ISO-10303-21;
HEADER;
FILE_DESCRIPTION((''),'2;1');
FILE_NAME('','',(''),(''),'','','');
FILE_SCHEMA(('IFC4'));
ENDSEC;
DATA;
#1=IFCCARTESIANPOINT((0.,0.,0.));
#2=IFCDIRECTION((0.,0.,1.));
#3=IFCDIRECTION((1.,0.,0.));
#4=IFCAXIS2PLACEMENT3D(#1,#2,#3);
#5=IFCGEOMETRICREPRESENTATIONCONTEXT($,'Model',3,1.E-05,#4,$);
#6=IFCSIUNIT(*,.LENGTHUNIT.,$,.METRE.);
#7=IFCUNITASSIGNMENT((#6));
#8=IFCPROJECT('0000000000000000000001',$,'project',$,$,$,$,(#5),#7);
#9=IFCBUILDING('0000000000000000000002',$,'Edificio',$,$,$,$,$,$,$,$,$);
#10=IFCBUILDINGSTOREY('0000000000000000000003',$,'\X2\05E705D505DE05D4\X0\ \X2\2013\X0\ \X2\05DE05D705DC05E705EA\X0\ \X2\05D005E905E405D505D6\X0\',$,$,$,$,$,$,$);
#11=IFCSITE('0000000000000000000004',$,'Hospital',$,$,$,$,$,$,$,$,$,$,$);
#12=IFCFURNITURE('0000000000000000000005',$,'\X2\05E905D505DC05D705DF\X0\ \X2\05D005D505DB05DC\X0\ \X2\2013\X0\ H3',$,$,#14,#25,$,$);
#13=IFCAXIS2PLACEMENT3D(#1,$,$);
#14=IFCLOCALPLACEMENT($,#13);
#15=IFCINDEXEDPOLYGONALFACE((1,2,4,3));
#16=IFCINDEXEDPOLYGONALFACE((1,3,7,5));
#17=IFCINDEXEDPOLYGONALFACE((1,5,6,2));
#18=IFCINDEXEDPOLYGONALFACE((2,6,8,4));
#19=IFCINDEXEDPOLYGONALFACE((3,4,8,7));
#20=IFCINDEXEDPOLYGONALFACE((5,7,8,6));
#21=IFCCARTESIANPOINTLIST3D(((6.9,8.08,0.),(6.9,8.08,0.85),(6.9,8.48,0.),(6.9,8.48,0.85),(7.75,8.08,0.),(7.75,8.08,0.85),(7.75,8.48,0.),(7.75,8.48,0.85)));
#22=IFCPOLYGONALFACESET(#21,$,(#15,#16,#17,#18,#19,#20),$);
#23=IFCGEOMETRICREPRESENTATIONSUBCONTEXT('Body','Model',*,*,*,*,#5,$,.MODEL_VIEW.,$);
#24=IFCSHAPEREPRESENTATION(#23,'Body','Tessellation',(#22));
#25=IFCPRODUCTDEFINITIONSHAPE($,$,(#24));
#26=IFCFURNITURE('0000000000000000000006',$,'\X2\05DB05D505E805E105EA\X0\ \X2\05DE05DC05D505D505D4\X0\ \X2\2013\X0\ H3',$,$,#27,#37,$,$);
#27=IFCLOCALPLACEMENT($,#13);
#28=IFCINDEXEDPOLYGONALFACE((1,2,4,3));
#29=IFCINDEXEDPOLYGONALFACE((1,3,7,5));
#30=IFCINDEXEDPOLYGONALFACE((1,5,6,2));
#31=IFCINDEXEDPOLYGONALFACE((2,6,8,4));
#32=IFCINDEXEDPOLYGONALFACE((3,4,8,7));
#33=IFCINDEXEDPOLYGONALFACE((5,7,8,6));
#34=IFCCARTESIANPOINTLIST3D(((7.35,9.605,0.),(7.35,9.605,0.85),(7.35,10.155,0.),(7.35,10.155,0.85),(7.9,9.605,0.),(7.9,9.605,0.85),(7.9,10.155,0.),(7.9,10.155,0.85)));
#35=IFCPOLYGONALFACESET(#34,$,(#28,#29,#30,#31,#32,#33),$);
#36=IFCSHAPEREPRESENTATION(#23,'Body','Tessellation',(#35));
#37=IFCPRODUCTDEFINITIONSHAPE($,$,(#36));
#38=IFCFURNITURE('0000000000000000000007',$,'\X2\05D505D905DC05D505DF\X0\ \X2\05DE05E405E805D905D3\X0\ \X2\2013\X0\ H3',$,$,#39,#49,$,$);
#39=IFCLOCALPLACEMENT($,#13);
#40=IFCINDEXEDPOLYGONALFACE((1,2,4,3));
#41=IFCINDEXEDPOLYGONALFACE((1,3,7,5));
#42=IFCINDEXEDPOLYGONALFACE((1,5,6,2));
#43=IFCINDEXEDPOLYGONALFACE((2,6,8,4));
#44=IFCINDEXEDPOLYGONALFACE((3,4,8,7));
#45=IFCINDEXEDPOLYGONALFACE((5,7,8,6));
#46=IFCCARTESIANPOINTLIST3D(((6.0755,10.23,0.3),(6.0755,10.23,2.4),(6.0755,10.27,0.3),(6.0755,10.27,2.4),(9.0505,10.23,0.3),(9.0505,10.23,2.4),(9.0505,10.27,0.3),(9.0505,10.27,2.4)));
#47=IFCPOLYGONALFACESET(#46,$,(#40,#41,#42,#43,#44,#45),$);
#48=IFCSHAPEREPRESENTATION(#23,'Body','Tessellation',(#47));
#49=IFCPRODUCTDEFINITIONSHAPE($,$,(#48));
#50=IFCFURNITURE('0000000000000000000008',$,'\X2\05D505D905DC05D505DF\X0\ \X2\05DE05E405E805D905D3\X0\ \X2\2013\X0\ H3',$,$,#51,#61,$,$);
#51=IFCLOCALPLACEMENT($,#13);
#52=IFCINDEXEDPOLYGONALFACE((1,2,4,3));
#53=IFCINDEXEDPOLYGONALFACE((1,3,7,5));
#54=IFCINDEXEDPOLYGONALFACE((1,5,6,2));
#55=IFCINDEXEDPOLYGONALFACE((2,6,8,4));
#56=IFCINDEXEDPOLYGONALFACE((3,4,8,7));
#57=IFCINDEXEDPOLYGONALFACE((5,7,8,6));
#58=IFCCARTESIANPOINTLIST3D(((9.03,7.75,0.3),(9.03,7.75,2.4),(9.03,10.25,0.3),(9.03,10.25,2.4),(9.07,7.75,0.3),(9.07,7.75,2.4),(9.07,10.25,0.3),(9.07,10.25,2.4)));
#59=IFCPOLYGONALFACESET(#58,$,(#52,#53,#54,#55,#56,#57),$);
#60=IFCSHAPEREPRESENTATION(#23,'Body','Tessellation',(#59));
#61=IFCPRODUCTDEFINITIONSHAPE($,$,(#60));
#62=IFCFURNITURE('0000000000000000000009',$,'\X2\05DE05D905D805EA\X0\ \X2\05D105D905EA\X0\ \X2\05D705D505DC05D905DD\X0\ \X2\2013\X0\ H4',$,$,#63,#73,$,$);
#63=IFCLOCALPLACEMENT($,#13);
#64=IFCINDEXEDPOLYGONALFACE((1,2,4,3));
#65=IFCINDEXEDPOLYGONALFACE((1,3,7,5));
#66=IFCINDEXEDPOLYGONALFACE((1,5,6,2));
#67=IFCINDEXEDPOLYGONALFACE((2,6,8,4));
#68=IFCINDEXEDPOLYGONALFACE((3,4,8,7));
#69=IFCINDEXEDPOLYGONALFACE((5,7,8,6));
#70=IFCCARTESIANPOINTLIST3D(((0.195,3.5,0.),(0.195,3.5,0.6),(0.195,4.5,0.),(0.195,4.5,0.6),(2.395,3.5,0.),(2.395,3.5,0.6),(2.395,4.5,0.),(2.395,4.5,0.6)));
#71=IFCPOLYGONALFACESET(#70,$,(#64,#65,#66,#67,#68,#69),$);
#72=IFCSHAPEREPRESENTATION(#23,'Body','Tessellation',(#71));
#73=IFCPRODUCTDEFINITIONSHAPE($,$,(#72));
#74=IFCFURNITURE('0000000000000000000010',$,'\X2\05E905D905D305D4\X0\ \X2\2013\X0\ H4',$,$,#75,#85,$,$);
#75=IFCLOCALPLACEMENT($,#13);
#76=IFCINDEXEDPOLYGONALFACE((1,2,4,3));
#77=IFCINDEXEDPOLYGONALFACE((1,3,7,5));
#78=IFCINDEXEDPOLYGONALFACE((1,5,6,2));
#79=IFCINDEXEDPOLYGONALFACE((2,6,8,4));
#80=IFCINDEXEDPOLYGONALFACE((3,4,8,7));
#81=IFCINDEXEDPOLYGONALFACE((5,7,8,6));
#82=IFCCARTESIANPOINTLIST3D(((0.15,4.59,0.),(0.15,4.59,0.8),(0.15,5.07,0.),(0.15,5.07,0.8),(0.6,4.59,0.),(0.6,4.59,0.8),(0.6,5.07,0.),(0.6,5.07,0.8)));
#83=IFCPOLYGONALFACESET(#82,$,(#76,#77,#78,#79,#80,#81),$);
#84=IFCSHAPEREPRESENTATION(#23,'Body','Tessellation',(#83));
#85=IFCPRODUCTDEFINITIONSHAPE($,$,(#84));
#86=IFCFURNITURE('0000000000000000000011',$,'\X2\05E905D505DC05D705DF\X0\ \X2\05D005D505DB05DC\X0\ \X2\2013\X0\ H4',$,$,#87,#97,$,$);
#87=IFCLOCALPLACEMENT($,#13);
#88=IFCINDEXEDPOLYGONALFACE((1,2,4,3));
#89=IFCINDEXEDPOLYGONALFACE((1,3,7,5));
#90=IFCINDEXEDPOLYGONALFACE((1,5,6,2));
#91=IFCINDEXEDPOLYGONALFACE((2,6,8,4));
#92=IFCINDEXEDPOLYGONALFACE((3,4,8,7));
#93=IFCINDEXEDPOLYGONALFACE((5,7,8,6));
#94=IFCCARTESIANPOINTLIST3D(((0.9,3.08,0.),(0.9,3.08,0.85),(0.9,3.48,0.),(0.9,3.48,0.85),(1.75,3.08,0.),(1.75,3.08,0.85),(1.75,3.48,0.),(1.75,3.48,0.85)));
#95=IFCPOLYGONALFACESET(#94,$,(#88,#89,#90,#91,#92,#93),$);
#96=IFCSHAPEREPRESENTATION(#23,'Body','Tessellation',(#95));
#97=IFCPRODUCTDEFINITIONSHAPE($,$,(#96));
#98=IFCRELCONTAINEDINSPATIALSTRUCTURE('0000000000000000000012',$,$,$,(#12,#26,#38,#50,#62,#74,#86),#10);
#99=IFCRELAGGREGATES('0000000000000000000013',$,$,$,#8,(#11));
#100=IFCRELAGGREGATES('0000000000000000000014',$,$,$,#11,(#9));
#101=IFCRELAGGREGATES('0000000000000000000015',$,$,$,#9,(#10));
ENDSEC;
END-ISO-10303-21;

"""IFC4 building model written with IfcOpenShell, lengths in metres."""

from ifc_helpers import new_model, si_unit, frame, origin_with_axes, context, subcontext, project, spatial, line, indexed_curve, outline, extrude, element, save


model = new_model("IFC4")

# Units and contexts
model_context = context("Model", 3, precision=1e-05, world=origin_with_axes())
body_context = subcontext(model_context, "Body", "Model", "MODEL_VIEW")
ifc_project = project(units=[si_unit("LENGTHUNIT", "METRE")], contexts=[model_context])

# Site, building, storey
site = spatial("IfcSite", under=ifc_project, Name="Hospital")
building = spatial("IfcBuilding", under=site, Name="Edificio")
storey = spatial("IfcBuildingStorey", under=building, Name="קומה – מחלקת אשפוז")

# Furniture
element("IfcFurniture", 1, inside=storey, Name="שולחן אוכל – H3", context=body_context, shape_type="SweptSolid", body=[
    extrude(outline(indexed_curve([(0.0, 0.0), (0.85, 0.0), (0.85, 0.4), (0.0, 0.4)], segments=[line(1, 2, 3, 4, 1)])), frame((6.9, 8.08, 0.0), z_axis=(0.0, 0.0, 1.0), x_axis=(1.0, 0.0, 0.0)), (0.0, 0.0, 1.0), 0.85),
])
element("IfcFurniture", 2, inside=storey, Name="כורסת מלווה – H3", context=body_context, shape_type="SweptSolid", body=[
    extrude(outline(indexed_curve([(0.0, 0.0), (0.55, 0.0), (0.55, 0.55), (0.0, 0.55)], segments=[line(1, 2, 3, 4, 1)])), frame((7.35, 9.605, 0.0), z_axis=(0.0, 0.0, 1.0), x_axis=(1.0, 0.0, 0.0)), (0.0, 0.0, 1.0), 0.85),
])
element("IfcFurniture", 3, inside=storey, Name="וילון מפריד – H3", context=body_context, shape_type="SweptSolid", body=[
    extrude(outline(indexed_curve([(0.0, 0.0), (2.975, 0.0), (2.975, 0.04), (0.0, 0.04)], segments=[line(1, 2, 3, 4, 1)])), frame((6.0755, 10.23, 0.3), z_axis=(0.0, 0.0, 1.0), x_axis=(1.0, 0.0, 0.0)), (0.0, 0.0, 1.0), 2.1),
])
element("IfcFurniture", 4, inside=storey, Name="וילון מפריד – H3", context=body_context, shape_type="SweptSolid", body=[
    extrude(outline(indexed_curve([(0.0, 0.0), (0.04, 0.0), (0.04, 2.5), (0.0, 2.5)], segments=[line(1, 2, 3, 4, 1)])), frame((9.03, 7.75, 0.3), z_axis=(0.0, 0.0, 1.0), x_axis=(1.0, 0.0, 0.0)), (0.0, 0.0, 1.0), 2.1),
])
element("IfcFurniture", 5, inside=storey, Name="מיטת בית חולים – H4", context=body_context, shape_type="SweptSolid", body=[
    extrude(outline(indexed_curve([(0.0, 0.0), (2.2, 0.0), (2.2, 1.0), (0.0, 1.0)], segments=[line(1, 2, 3, 4, 1)])), frame((0.195, 3.5, 0.0), z_axis=(0.0, 0.0, 1.0), x_axis=(1.0, 0.0, 0.0)), (0.0, 0.0, 1.0), 0.6),
])
element("IfcFurniture", 6, inside=storey, Name="שידה – H4", context=body_context, shape_type="SweptSolid", body=[
    extrude(outline(indexed_curve([(0.0, 0.0), (0.45, 0.0), (0.45, 0.48), (0.0, 0.48)], segments=[line(1, 2, 3, 4, 1)])), frame((0.15, 4.59, 0.0), z_axis=(0.0, 0.0, 1.0), x_axis=(1.0, 0.0, 0.0)), (0.0, 0.0, 1.0), 0.8),
])
element("IfcFurniture", 7, inside=storey, Name="שולחן אוכל – H4", context=body_context, shape_type="SweptSolid", body=[
    extrude(outline(indexed_curve([(0.0, 0.0), (0.85, 0.0), (0.85, 0.4), (0.0, 0.4)], segments=[line(1, 2, 3, 4, 1)])), frame((0.9, 3.08, 0.0), z_axis=(0.0, 0.0, 1.0), x_axis=(1.0, 0.0, 0.0)), (0.0, 0.0, 1.0), 0.85),
])

save(model, "model.ifc")
